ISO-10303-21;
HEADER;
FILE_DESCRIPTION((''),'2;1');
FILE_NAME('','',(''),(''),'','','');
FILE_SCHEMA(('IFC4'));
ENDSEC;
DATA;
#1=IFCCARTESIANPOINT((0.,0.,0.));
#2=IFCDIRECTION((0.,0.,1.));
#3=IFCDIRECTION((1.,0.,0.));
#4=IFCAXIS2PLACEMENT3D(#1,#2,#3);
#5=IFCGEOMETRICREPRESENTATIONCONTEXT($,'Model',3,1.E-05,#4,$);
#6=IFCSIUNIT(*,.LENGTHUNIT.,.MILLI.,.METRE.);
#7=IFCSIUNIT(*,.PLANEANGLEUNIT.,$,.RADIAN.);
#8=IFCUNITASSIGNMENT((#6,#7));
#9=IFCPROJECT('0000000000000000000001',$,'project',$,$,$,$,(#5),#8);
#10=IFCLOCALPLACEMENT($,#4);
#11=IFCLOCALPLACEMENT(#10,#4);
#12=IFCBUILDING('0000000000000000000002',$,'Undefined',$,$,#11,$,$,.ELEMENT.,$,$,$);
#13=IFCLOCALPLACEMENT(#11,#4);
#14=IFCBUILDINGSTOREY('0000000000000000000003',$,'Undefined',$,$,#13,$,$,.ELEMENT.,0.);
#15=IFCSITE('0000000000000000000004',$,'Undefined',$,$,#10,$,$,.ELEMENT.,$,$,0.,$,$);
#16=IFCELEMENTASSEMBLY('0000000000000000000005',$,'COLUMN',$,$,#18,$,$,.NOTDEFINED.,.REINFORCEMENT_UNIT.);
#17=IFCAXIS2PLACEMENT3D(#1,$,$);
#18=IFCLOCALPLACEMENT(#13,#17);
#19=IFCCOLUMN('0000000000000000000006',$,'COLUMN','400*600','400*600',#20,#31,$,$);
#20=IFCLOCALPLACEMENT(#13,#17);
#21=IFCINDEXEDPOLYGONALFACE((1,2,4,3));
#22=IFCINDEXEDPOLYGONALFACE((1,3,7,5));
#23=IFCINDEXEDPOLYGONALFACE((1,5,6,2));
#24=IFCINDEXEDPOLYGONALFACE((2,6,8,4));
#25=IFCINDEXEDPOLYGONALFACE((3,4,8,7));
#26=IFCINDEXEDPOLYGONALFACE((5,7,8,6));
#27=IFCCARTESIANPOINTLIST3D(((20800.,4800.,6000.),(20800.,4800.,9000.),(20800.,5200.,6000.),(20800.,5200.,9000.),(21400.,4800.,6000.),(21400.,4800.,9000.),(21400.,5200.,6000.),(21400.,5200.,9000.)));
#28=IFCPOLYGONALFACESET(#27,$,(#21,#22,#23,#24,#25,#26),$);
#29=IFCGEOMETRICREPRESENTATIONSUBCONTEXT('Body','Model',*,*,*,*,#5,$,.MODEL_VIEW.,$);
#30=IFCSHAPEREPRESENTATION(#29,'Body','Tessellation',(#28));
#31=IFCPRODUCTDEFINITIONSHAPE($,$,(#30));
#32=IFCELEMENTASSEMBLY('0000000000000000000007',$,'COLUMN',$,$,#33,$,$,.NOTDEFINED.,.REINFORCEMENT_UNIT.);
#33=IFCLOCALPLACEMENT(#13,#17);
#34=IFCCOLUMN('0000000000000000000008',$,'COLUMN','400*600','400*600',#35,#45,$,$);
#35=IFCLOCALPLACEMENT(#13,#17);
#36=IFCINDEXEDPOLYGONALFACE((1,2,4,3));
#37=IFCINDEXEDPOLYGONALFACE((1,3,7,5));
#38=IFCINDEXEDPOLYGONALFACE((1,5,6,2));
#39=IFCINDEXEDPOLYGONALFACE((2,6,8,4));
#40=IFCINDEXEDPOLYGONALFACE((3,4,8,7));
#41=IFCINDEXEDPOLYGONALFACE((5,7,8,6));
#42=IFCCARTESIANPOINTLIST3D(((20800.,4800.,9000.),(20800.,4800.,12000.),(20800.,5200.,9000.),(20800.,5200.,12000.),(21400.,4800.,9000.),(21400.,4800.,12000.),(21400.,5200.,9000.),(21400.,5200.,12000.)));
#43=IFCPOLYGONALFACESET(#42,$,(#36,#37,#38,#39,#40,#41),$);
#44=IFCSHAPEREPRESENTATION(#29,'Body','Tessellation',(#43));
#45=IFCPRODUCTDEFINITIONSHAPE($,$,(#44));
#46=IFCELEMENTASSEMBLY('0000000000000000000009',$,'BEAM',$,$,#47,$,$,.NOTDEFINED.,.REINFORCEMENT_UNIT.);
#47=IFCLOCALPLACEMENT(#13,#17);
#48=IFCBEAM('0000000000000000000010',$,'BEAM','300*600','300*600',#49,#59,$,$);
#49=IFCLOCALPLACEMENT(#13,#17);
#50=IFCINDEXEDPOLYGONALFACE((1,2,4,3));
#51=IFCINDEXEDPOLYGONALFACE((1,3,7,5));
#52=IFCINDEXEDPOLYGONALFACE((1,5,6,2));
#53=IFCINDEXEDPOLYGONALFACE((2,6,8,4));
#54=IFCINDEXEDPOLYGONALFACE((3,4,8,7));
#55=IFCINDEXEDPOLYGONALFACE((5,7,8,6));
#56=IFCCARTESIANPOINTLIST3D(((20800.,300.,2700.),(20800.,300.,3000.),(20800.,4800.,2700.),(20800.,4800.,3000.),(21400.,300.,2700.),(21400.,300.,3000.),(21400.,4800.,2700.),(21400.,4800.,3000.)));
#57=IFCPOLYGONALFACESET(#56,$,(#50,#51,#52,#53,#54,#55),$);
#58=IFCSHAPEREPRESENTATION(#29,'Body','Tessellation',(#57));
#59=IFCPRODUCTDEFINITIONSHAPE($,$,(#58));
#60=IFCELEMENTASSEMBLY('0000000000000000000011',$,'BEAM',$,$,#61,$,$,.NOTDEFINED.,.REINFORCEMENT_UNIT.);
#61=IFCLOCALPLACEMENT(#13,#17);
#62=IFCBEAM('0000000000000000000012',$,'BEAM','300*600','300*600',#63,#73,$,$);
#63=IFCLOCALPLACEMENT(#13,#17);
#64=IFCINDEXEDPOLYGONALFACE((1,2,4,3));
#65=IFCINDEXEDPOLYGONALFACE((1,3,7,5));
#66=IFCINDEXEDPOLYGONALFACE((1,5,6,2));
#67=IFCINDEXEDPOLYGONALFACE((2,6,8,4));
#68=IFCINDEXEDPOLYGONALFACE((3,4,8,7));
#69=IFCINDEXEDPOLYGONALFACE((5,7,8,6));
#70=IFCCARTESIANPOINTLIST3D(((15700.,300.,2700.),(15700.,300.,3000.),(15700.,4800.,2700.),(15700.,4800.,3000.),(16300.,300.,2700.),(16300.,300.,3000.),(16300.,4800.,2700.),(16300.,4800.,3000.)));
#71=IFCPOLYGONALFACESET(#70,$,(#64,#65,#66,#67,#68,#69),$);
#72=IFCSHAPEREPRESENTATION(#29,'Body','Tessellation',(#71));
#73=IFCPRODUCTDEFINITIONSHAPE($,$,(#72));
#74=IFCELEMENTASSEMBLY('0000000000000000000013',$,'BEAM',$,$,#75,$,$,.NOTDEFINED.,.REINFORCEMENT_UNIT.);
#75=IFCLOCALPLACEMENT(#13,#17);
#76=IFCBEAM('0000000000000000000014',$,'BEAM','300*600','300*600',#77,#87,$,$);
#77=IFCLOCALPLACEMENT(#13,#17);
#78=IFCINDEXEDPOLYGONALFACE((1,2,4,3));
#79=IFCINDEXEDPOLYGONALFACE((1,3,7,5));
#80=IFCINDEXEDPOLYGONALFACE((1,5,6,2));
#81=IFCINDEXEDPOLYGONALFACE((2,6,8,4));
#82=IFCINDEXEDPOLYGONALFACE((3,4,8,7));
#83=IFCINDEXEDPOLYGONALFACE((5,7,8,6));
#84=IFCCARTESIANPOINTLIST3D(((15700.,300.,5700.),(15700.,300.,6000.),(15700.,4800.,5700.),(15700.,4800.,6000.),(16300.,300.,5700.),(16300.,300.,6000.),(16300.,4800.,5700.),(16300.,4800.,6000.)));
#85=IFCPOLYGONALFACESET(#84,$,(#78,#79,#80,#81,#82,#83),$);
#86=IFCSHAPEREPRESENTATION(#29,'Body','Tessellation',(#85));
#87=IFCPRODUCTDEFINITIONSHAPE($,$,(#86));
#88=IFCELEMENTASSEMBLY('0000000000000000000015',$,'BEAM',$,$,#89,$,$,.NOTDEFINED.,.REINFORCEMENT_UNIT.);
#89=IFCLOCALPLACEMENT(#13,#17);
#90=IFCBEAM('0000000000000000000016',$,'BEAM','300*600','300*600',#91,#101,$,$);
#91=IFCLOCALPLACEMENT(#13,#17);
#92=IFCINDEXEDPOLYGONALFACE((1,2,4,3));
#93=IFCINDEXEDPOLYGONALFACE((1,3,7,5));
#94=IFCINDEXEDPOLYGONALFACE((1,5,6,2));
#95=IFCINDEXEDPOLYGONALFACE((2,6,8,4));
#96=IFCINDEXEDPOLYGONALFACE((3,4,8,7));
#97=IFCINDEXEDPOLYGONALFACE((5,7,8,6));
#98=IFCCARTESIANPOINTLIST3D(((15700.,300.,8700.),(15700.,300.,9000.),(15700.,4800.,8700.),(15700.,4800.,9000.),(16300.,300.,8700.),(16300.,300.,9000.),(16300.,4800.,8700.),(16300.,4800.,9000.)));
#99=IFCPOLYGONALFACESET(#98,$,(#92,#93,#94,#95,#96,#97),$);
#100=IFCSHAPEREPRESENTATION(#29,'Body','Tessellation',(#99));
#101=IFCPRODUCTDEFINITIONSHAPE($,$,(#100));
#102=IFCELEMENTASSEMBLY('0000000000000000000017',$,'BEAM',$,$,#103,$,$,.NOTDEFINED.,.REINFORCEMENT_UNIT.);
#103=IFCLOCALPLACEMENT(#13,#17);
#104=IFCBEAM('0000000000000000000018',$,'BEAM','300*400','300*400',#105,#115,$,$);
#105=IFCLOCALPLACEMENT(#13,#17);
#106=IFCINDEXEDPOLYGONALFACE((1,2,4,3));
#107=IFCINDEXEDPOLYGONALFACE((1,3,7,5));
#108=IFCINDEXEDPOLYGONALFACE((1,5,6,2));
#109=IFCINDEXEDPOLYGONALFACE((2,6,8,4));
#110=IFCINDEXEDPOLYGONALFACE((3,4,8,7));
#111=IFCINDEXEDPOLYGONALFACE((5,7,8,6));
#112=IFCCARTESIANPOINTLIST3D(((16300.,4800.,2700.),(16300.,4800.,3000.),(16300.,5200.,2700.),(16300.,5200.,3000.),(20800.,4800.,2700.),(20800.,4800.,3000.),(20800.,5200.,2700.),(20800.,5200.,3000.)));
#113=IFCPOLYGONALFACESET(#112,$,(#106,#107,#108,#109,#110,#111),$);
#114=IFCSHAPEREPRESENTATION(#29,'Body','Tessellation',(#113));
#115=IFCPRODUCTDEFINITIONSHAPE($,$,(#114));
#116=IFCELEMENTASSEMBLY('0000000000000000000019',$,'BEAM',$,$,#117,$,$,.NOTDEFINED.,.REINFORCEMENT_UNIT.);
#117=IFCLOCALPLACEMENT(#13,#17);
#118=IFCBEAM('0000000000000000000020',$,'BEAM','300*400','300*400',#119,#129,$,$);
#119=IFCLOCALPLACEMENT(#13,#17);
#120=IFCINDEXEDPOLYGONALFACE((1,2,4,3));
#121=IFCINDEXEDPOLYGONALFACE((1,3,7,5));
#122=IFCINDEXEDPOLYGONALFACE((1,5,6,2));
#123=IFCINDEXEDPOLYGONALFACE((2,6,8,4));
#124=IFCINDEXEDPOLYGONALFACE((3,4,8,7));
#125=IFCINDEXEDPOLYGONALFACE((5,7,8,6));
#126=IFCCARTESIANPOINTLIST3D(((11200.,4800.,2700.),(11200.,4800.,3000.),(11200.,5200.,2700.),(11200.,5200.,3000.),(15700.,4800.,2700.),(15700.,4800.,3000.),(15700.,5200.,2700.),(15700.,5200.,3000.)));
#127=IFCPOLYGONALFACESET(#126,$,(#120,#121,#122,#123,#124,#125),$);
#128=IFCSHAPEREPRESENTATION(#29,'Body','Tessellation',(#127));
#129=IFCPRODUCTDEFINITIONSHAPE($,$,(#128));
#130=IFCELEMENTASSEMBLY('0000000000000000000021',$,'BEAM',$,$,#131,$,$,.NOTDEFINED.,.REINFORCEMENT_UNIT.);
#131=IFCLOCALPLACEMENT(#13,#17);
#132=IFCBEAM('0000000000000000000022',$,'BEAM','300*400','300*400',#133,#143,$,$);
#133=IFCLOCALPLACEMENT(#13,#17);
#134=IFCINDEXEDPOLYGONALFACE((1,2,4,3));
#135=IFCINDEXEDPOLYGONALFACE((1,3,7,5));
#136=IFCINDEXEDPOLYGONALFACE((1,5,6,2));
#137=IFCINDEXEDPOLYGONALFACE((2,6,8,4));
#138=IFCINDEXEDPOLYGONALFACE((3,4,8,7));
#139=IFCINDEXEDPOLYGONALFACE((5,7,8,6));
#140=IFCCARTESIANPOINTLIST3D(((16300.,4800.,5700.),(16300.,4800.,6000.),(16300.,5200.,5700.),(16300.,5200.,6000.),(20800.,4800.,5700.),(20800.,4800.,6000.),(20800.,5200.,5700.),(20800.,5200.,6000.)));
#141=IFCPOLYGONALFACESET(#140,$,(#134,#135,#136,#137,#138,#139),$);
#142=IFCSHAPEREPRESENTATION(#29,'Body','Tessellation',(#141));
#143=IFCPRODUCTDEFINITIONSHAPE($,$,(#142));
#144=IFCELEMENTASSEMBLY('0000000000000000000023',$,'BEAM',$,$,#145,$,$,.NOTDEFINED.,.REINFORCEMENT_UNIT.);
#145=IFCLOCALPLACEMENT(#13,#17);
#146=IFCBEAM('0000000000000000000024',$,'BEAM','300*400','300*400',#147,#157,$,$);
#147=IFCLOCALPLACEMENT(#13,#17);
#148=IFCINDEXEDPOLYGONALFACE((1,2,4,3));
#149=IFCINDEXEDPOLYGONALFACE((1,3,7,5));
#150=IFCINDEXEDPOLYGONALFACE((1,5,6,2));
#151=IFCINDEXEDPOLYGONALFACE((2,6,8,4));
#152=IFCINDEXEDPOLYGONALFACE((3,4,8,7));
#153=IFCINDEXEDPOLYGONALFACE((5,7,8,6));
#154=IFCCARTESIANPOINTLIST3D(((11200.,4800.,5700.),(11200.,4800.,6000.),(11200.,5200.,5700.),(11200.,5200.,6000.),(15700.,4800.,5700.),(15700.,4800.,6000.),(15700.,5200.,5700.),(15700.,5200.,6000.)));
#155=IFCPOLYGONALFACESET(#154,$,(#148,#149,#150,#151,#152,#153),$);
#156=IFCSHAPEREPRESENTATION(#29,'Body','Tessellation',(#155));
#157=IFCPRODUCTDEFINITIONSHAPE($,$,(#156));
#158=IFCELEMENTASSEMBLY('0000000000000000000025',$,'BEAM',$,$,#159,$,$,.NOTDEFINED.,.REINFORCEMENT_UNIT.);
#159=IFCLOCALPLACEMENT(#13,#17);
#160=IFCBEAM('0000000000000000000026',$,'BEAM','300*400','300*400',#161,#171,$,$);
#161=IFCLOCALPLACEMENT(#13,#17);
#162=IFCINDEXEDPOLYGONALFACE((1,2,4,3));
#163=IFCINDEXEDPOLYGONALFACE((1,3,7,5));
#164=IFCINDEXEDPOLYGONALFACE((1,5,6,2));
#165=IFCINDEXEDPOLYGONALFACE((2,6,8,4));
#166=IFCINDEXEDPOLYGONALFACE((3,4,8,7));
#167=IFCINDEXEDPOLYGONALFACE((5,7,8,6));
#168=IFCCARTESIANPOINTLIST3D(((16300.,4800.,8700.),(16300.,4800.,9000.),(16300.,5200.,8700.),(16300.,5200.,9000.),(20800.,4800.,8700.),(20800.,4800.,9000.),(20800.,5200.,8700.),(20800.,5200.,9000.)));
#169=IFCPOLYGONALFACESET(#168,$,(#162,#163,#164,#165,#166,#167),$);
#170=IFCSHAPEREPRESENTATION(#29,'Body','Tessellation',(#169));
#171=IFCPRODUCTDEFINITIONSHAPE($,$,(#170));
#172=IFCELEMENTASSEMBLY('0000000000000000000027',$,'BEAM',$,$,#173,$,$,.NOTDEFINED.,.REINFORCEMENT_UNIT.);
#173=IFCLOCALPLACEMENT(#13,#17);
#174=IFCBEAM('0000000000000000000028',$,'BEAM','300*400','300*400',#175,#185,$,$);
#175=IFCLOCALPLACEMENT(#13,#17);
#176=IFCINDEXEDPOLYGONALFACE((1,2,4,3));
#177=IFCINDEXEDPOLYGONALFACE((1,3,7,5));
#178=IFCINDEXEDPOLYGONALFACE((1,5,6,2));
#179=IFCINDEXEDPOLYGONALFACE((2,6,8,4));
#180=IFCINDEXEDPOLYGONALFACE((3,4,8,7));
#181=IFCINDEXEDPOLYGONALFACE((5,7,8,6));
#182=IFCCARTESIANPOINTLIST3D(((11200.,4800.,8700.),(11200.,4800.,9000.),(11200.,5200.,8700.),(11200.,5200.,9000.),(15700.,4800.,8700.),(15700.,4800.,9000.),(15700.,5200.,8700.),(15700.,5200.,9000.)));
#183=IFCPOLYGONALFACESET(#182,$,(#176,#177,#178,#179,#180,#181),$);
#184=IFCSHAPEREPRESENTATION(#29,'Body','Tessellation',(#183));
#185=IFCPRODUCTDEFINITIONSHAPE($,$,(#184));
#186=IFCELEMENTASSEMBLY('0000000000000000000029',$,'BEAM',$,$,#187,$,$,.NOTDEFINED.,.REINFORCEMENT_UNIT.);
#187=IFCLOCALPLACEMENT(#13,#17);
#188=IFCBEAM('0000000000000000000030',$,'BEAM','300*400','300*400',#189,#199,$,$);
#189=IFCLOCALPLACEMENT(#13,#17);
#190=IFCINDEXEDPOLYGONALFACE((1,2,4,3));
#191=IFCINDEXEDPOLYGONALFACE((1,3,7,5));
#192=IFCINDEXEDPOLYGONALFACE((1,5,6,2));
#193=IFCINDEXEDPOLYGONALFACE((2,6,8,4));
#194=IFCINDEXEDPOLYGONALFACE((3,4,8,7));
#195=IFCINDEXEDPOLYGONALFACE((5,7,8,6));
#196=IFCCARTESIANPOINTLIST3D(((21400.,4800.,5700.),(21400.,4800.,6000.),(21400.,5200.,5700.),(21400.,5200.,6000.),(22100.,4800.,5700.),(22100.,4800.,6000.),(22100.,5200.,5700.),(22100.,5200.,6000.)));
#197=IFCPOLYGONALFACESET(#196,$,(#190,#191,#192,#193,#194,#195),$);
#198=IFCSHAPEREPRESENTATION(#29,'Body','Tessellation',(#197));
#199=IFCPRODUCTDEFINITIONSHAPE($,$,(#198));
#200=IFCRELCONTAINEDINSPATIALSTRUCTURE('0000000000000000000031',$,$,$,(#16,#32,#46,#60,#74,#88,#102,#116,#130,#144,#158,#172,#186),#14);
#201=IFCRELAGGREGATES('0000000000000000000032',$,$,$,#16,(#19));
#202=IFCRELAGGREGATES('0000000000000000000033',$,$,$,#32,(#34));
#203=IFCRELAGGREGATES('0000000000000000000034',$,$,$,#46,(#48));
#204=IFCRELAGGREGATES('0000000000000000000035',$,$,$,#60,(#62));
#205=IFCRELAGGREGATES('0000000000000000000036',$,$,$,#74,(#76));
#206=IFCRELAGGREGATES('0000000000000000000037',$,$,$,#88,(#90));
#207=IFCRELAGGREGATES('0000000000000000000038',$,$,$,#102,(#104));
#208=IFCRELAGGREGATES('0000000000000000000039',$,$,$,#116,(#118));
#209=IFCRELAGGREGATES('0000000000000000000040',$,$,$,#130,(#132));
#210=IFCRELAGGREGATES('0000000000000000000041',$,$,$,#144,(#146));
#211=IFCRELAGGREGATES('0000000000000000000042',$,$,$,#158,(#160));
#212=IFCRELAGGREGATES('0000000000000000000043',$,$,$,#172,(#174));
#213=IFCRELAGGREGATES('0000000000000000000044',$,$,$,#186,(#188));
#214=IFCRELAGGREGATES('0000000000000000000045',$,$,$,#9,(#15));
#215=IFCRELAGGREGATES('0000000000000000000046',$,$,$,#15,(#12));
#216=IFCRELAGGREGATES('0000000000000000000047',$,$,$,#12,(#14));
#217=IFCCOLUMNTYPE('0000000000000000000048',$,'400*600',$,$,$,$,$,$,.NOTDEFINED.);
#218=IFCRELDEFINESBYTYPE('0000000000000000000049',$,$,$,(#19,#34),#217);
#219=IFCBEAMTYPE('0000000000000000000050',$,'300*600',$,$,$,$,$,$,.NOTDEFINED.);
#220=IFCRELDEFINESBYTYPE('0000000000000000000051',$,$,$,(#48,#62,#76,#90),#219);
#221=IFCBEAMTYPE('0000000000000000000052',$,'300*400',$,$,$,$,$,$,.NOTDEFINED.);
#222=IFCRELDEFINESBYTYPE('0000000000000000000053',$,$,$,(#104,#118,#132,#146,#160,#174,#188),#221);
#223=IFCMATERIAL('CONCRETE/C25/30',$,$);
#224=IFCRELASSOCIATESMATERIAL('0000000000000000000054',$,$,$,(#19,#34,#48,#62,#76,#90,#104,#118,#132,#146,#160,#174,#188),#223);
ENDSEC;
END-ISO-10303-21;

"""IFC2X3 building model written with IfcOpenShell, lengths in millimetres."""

from ifc_helpers import new_model, si_unit, frame, origin_with_axes, origin_2d_with_axis, place, context, subcontext, project, spatial, rectangle, extrude, material, type_object, element, aggregate, save


model = new_model("IFC2X3")

# Units and contexts
model_context = context("Model", 3, precision=1e-05, world=origin_with_axes())
body_context = subcontext(model_context, "Body", "Model", "MODEL_VIEW")
ifc_project = project(units=[si_unit("LENGTHUNIT", "METRE", prefix="MILLI"), si_unit("PLANEANGLEUNIT", "RADIAN")], contexts=[model_context])

# Site, building, storey
site_placement = place(None, origin_with_axes())
site = spatial("IfcSite", under=ifc_project, at=site_placement, Name="Undefined", CompositionType="ELEMENT", RefElevation=0.0)
building_placement = place(site_placement, origin_with_axes())
building = spatial("IfcBuilding", under=site, at=building_placement, Name="Undefined", CompositionType="ELEMENT")
storey_placement = place(building_placement, origin_with_axes())
storey = spatial("IfcBuildingStorey", under=building, at=storey_placement, Name="Undefined", CompositionType="ELEMENT", Elevation=0.0)

# Shared definitions
ifc_material = material(Name="CONCRETE/C25/30")

# Element assemblies, columns
column_type_1 = type_object("IfcColumnType", Name="400*600", PredefinedType="NOTDEFINED")
assembly_1_placement = place(storey_placement, origin_with_axes())
assembly_1 = element("IfcElementAssembly", 1, at=assembly_1_placement, inside=storey, Name="COLUMN", AssemblyPlace="NOTDEFINED", PredefinedType="REINFORCEMENT_UNIT")
column_1_placement = place(assembly_1_placement, frame((21100.0, 5000.0, 6000.0), z_axis=(0.0, 0.0, 1.0), x_axis=(1.0, 0.0, 0.0)))
column_1 = element("IfcColumn", 2, at=column_1_placement, type_object=column_type_1, material=ifc_material, Name="COLUMN", Description="400*600", ObjectType="400*600", context=body_context, shape_type="SweptSolid", body=[
    extrude(rectangle(XDim=600.0, YDim=400.0, at=origin_2d_with_axis()), frame((0.0, 0.0, 3000.0), z_axis=(0.0, 0.0, -1.0), x_axis=(-1.0, 0.0, 0.0)), (0.0, 0.0, 1.0), 3000.0),
])
aggregate(assembly_1, [column_1])
assembly_2_placement = place(storey_placement, origin_with_axes())
assembly_2 = element("IfcElementAssembly", 3, at=assembly_2_placement, inside=storey, Name="COLUMN", AssemblyPlace="NOTDEFINED", PredefinedType="REINFORCEMENT_UNIT")
column_2_placement = place(assembly_2_placement, frame((21100.0, 5000.0, 9000.0), z_axis=(0.0, 0.0, 1.0), x_axis=(1.0, 0.0, 0.0)))
column_2 = element("IfcColumn", 4, at=column_2_placement, type_object=column_type_1, material=ifc_material, Name="COLUMN", Description="400*600", ObjectType="400*600", context=body_context, shape_type="SweptSolid", body=[
    extrude(rectangle(XDim=600.0, YDim=400.0, at=origin_2d_with_axis()), frame((0.0, 0.0, 3000.0), z_axis=(0.0, 0.0, -1.0), x_axis=(-1.0, 0.0, 0.0)), (0.0, 0.0, 1.0), 3000.0),
])
aggregate(assembly_2, [column_2])

# Element assemblies, beams
assembly_3_placement = place(storey_placement, origin_with_axes())
assembly_3 = element("IfcElementAssembly", 5, at=assembly_3_placement, inside=storey, Name="BEAM", AssemblyPlace="NOTDEFINED", PredefinedType="REINFORCEMENT_UNIT")
beam_type_1 = type_object("IfcBeamType", Name="300*600", PredefinedType="NOTDEFINED")
beam_1_placement = place(assembly_3_placement, frame((21100.0, 0.0, 2850.0), z_axis=(0.0, 0.0, 1.0), x_axis=(0.0, 1.0, 0.0)))
beam_1 = element("IfcBeam", 6, at=beam_1_placement, type_object=beam_type_1, material=ifc_material, Name="BEAM", Description="300*600", ObjectType="300*600", context=body_context, shape_type="SweptSolid", body=[
    extrude(rectangle(XDim=600.0, YDim=300.0, at=origin_2d_with_axis()), frame((4800.0, 0.0, 0.0), z_axis=(-1.0, 0.0, 0.0), x_axis=(0.0, -1.0, 0.0)), (0.0, 0.0, 1.0), 4500.0),
])
aggregate(assembly_3, [beam_1])
assembly_4_placement = place(storey_placement, origin_with_axes())
assembly_4 = element("IfcElementAssembly", 7, at=assembly_4_placement, inside=storey, Name="BEAM", AssemblyPlace="NOTDEFINED", PredefinedType="REINFORCEMENT_UNIT")
beam_2_placement = place(assembly_4_placement, frame((16000.0, 0.0, 2850.0), z_axis=(0.0, 0.0, 1.0), x_axis=(0.0, 1.0, 0.0)))
beam_2 = element("IfcBeam", 8, at=beam_2_placement, type_object=beam_type_1, material=ifc_material, Name="BEAM", Description="300*600", ObjectType="300*600", context=body_context, shape_type="SweptSolid", body=[
    extrude(rectangle(XDim=600.0, YDim=300.0, at=origin_2d_with_axis()), frame((4800.0, 0.0, 0.0), z_axis=(-1.0, 0.0, 0.0), x_axis=(0.0, -1.0, 0.0)), (0.0, 0.0, 1.0), 4500.0),
])
aggregate(assembly_4, [beam_2])
assembly_5_placement = place(storey_placement, origin_with_axes())
assembly_5 = element("IfcElementAssembly", 9, at=assembly_5_placement, inside=storey, Name="BEAM", AssemblyPlace="NOTDEFINED", PredefinedType="REINFORCEMENT_UNIT")
beam_3_placement = place(assembly_5_placement, frame((16000.0, 0.0, 5850.0), z_axis=(0.0, 0.0, 1.0), x_axis=(0.0, 1.0, 0.0)))
beam_3 = element("IfcBeam", 10, at=beam_3_placement, type_object=beam_type_1, material=ifc_material, Name="BEAM", Description="300*600", ObjectType="300*600", context=body_context, shape_type="SweptSolid", body=[
    extrude(rectangle(XDim=600.0, YDim=300.0, at=origin_2d_with_axis()), frame((4800.0, 0.0, 0.0), z_axis=(-1.0, 0.0, 0.0), x_axis=(0.0, -1.0, 0.0)), (0.0, 0.0, 1.0), 4500.0),
])
aggregate(assembly_5, [beam_3])
assembly_6_placement = place(storey_placement, origin_with_axes())
assembly_6 = element("IfcElementAssembly", 11, at=assembly_6_placement, inside=storey, Name="BEAM", AssemblyPlace="NOTDEFINED", PredefinedType="REINFORCEMENT_UNIT")
beam_4_placement = place(assembly_6_placement, frame((16000.0, 0.0, 8850.0), z_axis=(0.0, 0.0, 1.0), x_axis=(0.0, 1.0, 0.0)))
beam_4 = element("IfcBeam", 12, at=beam_4_placement, type_object=beam_type_1, material=ifc_material, Name="BEAM", Description="300*600", ObjectType="300*600", context=body_context, shape_type="SweptSolid", body=[
    extrude(rectangle(XDim=600.0, YDim=300.0, at=origin_2d_with_axis()), frame((4800.0, 0.0, 0.0), z_axis=(-1.0, 0.0, 0.0), x_axis=(0.0, -1.0, 0.0)), (0.0, 0.0, 1.0), 4500.0),
])
aggregate(assembly_6, [beam_4])
assembly_7_placement = place(storey_placement, origin_with_axes())
assembly_7 = element("IfcElementAssembly", 13, at=assembly_7_placement, inside=storey, Name="BEAM", AssemblyPlace="NOTDEFINED", PredefinedType="REINFORCEMENT_UNIT")
beam_type_2 = type_object("IfcBeamType", Name="300*400", PredefinedType="NOTDEFINED")
beam_5_placement = place(assembly_7_placement, frame((21100.0, 5000.0, 2850.0), z_axis=(0.0, 0.0, 1.0), x_axis=(-1.0, 0.0, 0.0)))
beam_5 = element("IfcBeam", 14, at=beam_5_placement, type_object=beam_type_2, material=ifc_material, Name="BEAM", Description="300*400", ObjectType="300*400", context=body_context, shape_type="SweptSolid", body=[
    extrude(rectangle(XDim=400.0, YDim=300.0, at=origin_2d_with_axis()), frame((4800.0, 0.0, 0.0), z_axis=(-1.0, 0.0, 0.0), x_axis=(0.0, -1.0, 0.0)), (0.0, 0.0, 1.0), 4500.0),
])
aggregate(assembly_7, [beam_5])
assembly_8_placement = place(storey_placement, origin_with_axes())
assembly_8 = element("IfcElementAssembly", 15, at=assembly_8_placement, inside=storey, Name="BEAM", AssemblyPlace="NOTDEFINED", PredefinedType="REINFORCEMENT_UNIT")
beam_6_placement = place(assembly_8_placement, frame((16000.0, 5000.0, 2850.0), z_axis=(0.0, 0.0, 1.0), x_axis=(-1.0, 0.0, 0.0)))
beam_6 = element("IfcBeam", 16, at=beam_6_placement, type_object=beam_type_2, material=ifc_material, Name="BEAM", Description="300*400", ObjectType="300*400", context=body_context, shape_type="SweptSolid", body=[
    extrude(rectangle(XDim=400.0, YDim=300.0, at=origin_2d_with_axis()), frame((4800.0, 0.0, 0.0), z_axis=(-1.0, 0.0, 0.0), x_axis=(0.0, -1.0, 0.0)), (0.0, 0.0, 1.0), 4500.0),
])
aggregate(assembly_8, [beam_6])
assembly_9_placement = place(storey_placement, origin_with_axes())
assembly_9 = element("IfcElementAssembly", 17, at=assembly_9_placement, inside=storey, Name="BEAM", AssemblyPlace="NOTDEFINED", PredefinedType="REINFORCEMENT_UNIT")
beam_7_placement = place(assembly_9_placement, frame((21100.0, 5000.0, 5850.0), z_axis=(0.0, 0.0, 1.0), x_axis=(-1.0, 0.0, 0.0)))
beam_7 = element("IfcBeam", 18, at=beam_7_placement, type_object=beam_type_2, material=ifc_material, Name="BEAM", Description="300*400", ObjectType="300*400", context=body_context, shape_type="SweptSolid", body=[
    extrude(rectangle(XDim=400.0, YDim=300.0, at=origin_2d_with_axis()), frame((4800.0, 0.0, 0.0), z_axis=(-1.0, 0.0, 0.0), x_axis=(0.0, -1.0, 0.0)), (0.0, 0.0, 1.0), 4500.0),
])
aggregate(assembly_9, [beam_7])
assembly_10_placement = place(storey_placement, origin_with_axes())
assembly_10 = element("IfcElementAssembly", 19, at=assembly_10_placement, inside=storey, Name="BEAM", AssemblyPlace="NOTDEFINED", PredefinedType="REINFORCEMENT_UNIT")
beam_8_placement = place(assembly_10_placement, frame((16000.0, 5000.0, 5850.0), z_axis=(0.0, 0.0, 1.0), x_axis=(-1.0, 0.0, 0.0)))
beam_8 = element("IfcBeam", 20, at=beam_8_placement, type_object=beam_type_2, material=ifc_material, Name="BEAM", Description="300*400", ObjectType="300*400", context=body_context, shape_type="SweptSolid", body=[
    extrude(rectangle(XDim=400.0, YDim=300.0, at=origin_2d_with_axis()), frame((4800.0, 0.0, 0.0), z_axis=(-1.0, 0.0, 0.0), x_axis=(0.0, -1.0, 0.0)), (0.0, 0.0, 1.0), 4500.0),
])
aggregate(assembly_10, [beam_8])
assembly_11_placement = place(storey_placement, origin_with_axes())
assembly_11 = element("IfcElementAssembly", 21, at=assembly_11_placement, inside=storey, Name="BEAM", AssemblyPlace="NOTDEFINED", PredefinedType="REINFORCEMENT_UNIT")
beam_9_placement = place(assembly_11_placement, frame((21100.0, 5000.0, 8850.0), z_axis=(0.0, 0.0, 1.0), x_axis=(-1.0, 0.0, 0.0)))
beam_9 = element("IfcBeam", 22, at=beam_9_placement, type_object=beam_type_2, material=ifc_material, Name="BEAM", Description="300*400", ObjectType="300*400", context=body_context, shape_type="SweptSolid", body=[
    extrude(rectangle(XDim=400.0, YDim=300.0, at=origin_2d_with_axis()), frame((4800.0, 0.0, 0.0), z_axis=(-1.0, 0.0, 0.0), x_axis=(0.0, -1.0, 0.0)), (0.0, 0.0, 1.0), 4500.0),
])
aggregate(assembly_11, [beam_9])
assembly_12_placement = place(storey_placement, origin_with_axes())
assembly_12 = element("IfcElementAssembly", 23, at=assembly_12_placement, inside=storey, Name="BEAM", AssemblyPlace="NOTDEFINED", PredefinedType="REINFORCEMENT_UNIT")
beam_10_placement = place(assembly_12_placement, frame((16000.0, 5000.0, 8850.0), z_axis=(0.0, 0.0, 1.0), x_axis=(-1.0, 0.0, 0.0)))
beam_10 = element("IfcBeam", 24, at=beam_10_placement, type_object=beam_type_2, material=ifc_material, Name="BEAM", Description="300*400", ObjectType="300*400", context=body_context, shape_type="SweptSolid", body=[
    extrude(rectangle(XDim=400.0, YDim=300.0, at=origin_2d_with_axis()), frame((4800.0, 0.0, 0.0), z_axis=(-1.0, 0.0, 0.0), x_axis=(0.0, -1.0, 0.0)), (0.0, 0.0, 1.0), 4500.0),
])
aggregate(assembly_12, [beam_10])
assembly_13_placement = place(storey_placement, origin_with_axes())
assembly_13 = element("IfcElementAssembly", 25, at=assembly_13_placement, inside=storey, Name="BEAM", AssemblyPlace="NOTDEFINED", PredefinedType="REINFORCEMENT_UNIT")
beam_11_placement = place(assembly_13_placement, frame((21400.0, 5000.0, 5850.0), z_axis=(0.0, 0.0, 1.0), x_axis=(1.0, 0.0, 0.0)))
beam_11 = element("IfcBeam", 26, at=beam_11_placement, type_object=beam_type_2, material=ifc_material, Name="BEAM", Description="300*400", ObjectType="300*400", context=body_context, shape_type="SweptSolid", body=[
    extrude(rectangle(XDim=400.0, YDim=300.0, at=origin_2d_with_axis()), frame((700.0, 0.0, 0.0), z_axis=(-1.0, 0.0, 0.0), x_axis=(0.0, -1.0, 0.0)), (0.0, 0.0, 1.0), 700.0),
])
aggregate(assembly_13, [beam_11])

save(model, "model.ifc")
